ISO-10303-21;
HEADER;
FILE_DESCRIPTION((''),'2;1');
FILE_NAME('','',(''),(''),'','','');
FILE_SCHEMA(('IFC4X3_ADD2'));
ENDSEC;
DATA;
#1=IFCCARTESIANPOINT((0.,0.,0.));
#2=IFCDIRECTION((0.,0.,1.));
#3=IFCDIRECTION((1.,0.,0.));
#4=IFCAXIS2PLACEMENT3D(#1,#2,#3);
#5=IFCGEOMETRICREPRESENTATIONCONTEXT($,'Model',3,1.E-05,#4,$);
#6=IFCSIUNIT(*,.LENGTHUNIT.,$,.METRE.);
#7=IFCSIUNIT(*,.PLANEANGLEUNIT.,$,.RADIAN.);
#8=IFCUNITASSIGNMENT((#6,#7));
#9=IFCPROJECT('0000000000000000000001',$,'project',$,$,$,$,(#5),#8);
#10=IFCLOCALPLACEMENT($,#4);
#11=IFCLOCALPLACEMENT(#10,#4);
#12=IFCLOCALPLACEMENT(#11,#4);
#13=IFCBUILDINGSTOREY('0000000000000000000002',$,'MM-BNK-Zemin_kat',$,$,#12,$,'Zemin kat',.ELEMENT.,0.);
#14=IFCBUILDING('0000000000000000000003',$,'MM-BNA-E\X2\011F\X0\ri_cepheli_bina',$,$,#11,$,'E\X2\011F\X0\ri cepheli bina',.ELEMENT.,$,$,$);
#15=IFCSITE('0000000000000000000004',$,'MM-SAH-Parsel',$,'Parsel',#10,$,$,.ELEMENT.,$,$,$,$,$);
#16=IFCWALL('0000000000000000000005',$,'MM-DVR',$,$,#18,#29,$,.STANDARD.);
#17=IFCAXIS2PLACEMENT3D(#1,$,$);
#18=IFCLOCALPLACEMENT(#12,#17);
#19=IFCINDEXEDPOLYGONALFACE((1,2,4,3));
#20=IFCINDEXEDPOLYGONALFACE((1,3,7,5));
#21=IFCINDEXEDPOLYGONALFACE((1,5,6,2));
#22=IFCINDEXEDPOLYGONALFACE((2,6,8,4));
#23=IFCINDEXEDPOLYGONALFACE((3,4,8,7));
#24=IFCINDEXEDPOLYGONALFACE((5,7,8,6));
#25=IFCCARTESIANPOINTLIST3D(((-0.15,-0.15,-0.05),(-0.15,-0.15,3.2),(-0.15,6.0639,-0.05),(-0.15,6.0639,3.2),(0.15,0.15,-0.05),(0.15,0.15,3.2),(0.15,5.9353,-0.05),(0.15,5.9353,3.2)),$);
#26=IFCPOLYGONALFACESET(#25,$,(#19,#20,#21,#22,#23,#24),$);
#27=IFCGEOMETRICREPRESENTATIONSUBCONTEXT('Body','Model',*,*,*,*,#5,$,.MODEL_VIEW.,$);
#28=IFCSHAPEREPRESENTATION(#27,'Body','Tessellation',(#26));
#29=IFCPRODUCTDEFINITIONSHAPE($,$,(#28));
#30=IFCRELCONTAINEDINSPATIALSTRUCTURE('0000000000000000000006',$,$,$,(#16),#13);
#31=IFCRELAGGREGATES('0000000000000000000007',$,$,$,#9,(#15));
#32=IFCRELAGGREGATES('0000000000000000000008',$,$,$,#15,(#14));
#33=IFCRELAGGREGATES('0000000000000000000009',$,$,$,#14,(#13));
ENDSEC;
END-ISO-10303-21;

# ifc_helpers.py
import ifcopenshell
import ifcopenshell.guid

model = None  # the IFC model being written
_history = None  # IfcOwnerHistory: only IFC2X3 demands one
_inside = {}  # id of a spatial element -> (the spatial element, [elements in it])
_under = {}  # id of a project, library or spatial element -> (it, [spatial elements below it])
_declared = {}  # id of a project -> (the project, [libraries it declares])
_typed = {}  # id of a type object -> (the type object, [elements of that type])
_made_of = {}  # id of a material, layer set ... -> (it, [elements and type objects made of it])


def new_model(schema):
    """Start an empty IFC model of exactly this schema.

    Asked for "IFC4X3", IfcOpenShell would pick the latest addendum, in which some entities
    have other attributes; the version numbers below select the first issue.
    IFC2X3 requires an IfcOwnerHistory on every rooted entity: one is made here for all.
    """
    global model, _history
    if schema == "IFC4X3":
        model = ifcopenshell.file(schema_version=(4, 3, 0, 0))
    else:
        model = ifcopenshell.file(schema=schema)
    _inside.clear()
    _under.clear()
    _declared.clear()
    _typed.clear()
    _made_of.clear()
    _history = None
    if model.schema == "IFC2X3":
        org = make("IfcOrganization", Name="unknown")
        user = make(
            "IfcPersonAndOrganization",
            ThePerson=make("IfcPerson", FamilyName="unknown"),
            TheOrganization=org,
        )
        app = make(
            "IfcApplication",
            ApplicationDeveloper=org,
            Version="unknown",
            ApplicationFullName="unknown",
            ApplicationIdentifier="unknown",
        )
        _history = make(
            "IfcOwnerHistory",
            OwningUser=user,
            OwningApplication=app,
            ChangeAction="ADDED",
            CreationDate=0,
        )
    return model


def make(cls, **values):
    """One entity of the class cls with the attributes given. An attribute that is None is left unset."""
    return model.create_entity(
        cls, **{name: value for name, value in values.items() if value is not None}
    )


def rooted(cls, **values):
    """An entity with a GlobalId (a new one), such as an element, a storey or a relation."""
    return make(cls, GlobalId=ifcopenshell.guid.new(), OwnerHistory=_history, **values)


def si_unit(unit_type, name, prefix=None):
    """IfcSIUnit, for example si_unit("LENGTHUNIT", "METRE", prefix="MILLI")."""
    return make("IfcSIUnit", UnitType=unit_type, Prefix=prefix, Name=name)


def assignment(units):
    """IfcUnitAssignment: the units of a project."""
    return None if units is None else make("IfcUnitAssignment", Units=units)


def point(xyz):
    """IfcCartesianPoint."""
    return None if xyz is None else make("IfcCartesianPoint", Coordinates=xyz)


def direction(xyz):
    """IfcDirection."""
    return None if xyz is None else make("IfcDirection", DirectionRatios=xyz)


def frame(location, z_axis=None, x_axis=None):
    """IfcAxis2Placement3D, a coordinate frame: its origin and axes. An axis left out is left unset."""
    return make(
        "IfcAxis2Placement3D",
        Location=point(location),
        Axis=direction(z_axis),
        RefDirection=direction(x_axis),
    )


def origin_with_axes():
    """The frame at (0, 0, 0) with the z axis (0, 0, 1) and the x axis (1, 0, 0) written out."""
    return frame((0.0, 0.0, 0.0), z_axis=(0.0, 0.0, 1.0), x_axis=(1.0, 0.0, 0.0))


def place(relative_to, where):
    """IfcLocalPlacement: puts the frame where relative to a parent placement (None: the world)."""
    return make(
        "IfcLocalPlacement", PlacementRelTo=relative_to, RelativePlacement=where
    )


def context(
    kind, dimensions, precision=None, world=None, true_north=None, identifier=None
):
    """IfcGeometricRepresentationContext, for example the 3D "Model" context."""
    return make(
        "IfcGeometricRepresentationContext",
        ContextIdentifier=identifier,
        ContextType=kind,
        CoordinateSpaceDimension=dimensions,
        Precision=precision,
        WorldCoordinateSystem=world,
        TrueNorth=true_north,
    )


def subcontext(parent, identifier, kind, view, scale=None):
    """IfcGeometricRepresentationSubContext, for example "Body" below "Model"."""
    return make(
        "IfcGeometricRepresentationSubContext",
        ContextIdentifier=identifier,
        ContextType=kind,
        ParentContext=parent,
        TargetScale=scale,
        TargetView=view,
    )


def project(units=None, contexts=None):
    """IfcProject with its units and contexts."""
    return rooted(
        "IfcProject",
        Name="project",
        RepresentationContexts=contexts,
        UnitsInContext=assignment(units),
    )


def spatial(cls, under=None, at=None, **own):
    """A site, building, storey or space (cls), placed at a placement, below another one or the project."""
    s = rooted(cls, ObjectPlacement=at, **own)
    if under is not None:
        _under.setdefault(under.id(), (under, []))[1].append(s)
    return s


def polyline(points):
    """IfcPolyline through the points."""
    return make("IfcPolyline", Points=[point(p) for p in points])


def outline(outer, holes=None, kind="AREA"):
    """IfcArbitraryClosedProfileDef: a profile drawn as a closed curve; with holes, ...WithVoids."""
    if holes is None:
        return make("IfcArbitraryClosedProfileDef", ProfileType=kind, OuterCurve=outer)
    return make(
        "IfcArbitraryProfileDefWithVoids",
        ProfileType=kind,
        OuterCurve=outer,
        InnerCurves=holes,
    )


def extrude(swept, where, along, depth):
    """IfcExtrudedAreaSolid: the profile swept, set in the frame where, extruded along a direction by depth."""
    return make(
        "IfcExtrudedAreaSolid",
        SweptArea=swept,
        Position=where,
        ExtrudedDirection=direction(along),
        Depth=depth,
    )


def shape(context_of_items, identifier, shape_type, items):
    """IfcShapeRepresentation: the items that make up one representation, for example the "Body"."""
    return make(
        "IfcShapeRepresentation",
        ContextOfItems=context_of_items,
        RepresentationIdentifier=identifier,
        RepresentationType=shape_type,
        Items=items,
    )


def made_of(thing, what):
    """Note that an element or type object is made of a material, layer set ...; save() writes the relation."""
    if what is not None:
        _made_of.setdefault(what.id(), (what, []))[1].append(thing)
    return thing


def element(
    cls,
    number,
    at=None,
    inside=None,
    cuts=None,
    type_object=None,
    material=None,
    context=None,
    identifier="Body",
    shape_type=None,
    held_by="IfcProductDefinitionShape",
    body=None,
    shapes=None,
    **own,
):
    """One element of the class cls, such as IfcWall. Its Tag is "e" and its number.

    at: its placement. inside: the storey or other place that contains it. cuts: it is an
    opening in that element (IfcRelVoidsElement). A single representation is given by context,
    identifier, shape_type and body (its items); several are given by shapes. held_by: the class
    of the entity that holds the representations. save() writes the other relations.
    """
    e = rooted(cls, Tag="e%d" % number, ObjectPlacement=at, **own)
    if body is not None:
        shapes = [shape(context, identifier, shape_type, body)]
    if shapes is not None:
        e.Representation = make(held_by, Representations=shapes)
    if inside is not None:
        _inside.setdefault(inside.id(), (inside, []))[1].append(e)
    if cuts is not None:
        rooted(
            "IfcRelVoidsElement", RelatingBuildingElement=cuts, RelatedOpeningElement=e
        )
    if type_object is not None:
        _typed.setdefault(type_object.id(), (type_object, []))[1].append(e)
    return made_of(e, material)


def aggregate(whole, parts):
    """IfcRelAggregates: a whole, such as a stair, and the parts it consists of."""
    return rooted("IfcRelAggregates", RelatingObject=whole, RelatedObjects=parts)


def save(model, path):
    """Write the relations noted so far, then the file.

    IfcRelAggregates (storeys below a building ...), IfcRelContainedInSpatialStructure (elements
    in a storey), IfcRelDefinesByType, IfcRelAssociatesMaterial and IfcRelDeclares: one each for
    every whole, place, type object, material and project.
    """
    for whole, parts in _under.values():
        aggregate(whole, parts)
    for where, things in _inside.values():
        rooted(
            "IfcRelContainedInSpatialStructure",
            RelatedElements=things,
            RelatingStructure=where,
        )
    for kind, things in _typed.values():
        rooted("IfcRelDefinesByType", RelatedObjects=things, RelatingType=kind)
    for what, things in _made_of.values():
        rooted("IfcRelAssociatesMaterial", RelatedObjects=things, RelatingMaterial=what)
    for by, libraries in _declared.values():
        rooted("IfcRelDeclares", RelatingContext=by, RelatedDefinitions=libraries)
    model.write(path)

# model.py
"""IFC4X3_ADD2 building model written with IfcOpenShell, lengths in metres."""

from ifc_helpers import new_model, si_unit, frame, origin_with_axes, place, context, subcontext, project, spatial, polyline, outline, extrude, element, save


model = new_model("IFC4X3_ADD2")

# Units and contexts
model_context = context("Model", 3, precision=1e-05, world=origin_with_axes())
body_context = subcontext(model_context, "Body", "Model", "MODEL_VIEW")
ifc_project = project(units=[si_unit("LENGTHUNIT", "METRE"), si_unit("PLANEANGLEUNIT", "RADIAN")], contexts=[model_context])

# Site, building, storey
site_placement = place(None, origin_with_axes())
site = spatial("IfcSite", under=ifc_project, at=site_placement, Name="MM-SAH-Parsel", ObjectType="Parsel", CompositionType="ELEMENT")
building_placement = place(site_placement, origin_with_axes())
building = spatial("IfcBuilding", under=site, at=building_placement, Name="MM-BNA-Eğri_cepheli_bina", LongName="Eğri cepheli bina", CompositionType="ELEMENT")
storey_placement = place(building_placement, origin_with_axes())
storey = spatial("IfcBuildingStorey", under=building, at=storey_placement, Name="MM-BNK-Zemin_kat", LongName="Zemin kat", CompositionType="ELEMENT", Elevation=0.0)

# Wall
wall_1_placement = place(storey_placement, origin_with_axes())
element("IfcWall", 1, at=wall_1_placement, inside=storey, Name="MM-DVR", PredefinedType="STANDARD", context=body_context, shape_type="SweptSolid", body=[
    extrude(outline(polyline([(0.15, 5.9353), (0.15, 0.15), (-0.15, -0.15), (-0.15, 6.0639), (0.15, 5.9353)])), frame((0.0, 0.0, -0.05)), (0.0, 0.0, 1.0), 3.25),
])

save(model, "model.ifc")
